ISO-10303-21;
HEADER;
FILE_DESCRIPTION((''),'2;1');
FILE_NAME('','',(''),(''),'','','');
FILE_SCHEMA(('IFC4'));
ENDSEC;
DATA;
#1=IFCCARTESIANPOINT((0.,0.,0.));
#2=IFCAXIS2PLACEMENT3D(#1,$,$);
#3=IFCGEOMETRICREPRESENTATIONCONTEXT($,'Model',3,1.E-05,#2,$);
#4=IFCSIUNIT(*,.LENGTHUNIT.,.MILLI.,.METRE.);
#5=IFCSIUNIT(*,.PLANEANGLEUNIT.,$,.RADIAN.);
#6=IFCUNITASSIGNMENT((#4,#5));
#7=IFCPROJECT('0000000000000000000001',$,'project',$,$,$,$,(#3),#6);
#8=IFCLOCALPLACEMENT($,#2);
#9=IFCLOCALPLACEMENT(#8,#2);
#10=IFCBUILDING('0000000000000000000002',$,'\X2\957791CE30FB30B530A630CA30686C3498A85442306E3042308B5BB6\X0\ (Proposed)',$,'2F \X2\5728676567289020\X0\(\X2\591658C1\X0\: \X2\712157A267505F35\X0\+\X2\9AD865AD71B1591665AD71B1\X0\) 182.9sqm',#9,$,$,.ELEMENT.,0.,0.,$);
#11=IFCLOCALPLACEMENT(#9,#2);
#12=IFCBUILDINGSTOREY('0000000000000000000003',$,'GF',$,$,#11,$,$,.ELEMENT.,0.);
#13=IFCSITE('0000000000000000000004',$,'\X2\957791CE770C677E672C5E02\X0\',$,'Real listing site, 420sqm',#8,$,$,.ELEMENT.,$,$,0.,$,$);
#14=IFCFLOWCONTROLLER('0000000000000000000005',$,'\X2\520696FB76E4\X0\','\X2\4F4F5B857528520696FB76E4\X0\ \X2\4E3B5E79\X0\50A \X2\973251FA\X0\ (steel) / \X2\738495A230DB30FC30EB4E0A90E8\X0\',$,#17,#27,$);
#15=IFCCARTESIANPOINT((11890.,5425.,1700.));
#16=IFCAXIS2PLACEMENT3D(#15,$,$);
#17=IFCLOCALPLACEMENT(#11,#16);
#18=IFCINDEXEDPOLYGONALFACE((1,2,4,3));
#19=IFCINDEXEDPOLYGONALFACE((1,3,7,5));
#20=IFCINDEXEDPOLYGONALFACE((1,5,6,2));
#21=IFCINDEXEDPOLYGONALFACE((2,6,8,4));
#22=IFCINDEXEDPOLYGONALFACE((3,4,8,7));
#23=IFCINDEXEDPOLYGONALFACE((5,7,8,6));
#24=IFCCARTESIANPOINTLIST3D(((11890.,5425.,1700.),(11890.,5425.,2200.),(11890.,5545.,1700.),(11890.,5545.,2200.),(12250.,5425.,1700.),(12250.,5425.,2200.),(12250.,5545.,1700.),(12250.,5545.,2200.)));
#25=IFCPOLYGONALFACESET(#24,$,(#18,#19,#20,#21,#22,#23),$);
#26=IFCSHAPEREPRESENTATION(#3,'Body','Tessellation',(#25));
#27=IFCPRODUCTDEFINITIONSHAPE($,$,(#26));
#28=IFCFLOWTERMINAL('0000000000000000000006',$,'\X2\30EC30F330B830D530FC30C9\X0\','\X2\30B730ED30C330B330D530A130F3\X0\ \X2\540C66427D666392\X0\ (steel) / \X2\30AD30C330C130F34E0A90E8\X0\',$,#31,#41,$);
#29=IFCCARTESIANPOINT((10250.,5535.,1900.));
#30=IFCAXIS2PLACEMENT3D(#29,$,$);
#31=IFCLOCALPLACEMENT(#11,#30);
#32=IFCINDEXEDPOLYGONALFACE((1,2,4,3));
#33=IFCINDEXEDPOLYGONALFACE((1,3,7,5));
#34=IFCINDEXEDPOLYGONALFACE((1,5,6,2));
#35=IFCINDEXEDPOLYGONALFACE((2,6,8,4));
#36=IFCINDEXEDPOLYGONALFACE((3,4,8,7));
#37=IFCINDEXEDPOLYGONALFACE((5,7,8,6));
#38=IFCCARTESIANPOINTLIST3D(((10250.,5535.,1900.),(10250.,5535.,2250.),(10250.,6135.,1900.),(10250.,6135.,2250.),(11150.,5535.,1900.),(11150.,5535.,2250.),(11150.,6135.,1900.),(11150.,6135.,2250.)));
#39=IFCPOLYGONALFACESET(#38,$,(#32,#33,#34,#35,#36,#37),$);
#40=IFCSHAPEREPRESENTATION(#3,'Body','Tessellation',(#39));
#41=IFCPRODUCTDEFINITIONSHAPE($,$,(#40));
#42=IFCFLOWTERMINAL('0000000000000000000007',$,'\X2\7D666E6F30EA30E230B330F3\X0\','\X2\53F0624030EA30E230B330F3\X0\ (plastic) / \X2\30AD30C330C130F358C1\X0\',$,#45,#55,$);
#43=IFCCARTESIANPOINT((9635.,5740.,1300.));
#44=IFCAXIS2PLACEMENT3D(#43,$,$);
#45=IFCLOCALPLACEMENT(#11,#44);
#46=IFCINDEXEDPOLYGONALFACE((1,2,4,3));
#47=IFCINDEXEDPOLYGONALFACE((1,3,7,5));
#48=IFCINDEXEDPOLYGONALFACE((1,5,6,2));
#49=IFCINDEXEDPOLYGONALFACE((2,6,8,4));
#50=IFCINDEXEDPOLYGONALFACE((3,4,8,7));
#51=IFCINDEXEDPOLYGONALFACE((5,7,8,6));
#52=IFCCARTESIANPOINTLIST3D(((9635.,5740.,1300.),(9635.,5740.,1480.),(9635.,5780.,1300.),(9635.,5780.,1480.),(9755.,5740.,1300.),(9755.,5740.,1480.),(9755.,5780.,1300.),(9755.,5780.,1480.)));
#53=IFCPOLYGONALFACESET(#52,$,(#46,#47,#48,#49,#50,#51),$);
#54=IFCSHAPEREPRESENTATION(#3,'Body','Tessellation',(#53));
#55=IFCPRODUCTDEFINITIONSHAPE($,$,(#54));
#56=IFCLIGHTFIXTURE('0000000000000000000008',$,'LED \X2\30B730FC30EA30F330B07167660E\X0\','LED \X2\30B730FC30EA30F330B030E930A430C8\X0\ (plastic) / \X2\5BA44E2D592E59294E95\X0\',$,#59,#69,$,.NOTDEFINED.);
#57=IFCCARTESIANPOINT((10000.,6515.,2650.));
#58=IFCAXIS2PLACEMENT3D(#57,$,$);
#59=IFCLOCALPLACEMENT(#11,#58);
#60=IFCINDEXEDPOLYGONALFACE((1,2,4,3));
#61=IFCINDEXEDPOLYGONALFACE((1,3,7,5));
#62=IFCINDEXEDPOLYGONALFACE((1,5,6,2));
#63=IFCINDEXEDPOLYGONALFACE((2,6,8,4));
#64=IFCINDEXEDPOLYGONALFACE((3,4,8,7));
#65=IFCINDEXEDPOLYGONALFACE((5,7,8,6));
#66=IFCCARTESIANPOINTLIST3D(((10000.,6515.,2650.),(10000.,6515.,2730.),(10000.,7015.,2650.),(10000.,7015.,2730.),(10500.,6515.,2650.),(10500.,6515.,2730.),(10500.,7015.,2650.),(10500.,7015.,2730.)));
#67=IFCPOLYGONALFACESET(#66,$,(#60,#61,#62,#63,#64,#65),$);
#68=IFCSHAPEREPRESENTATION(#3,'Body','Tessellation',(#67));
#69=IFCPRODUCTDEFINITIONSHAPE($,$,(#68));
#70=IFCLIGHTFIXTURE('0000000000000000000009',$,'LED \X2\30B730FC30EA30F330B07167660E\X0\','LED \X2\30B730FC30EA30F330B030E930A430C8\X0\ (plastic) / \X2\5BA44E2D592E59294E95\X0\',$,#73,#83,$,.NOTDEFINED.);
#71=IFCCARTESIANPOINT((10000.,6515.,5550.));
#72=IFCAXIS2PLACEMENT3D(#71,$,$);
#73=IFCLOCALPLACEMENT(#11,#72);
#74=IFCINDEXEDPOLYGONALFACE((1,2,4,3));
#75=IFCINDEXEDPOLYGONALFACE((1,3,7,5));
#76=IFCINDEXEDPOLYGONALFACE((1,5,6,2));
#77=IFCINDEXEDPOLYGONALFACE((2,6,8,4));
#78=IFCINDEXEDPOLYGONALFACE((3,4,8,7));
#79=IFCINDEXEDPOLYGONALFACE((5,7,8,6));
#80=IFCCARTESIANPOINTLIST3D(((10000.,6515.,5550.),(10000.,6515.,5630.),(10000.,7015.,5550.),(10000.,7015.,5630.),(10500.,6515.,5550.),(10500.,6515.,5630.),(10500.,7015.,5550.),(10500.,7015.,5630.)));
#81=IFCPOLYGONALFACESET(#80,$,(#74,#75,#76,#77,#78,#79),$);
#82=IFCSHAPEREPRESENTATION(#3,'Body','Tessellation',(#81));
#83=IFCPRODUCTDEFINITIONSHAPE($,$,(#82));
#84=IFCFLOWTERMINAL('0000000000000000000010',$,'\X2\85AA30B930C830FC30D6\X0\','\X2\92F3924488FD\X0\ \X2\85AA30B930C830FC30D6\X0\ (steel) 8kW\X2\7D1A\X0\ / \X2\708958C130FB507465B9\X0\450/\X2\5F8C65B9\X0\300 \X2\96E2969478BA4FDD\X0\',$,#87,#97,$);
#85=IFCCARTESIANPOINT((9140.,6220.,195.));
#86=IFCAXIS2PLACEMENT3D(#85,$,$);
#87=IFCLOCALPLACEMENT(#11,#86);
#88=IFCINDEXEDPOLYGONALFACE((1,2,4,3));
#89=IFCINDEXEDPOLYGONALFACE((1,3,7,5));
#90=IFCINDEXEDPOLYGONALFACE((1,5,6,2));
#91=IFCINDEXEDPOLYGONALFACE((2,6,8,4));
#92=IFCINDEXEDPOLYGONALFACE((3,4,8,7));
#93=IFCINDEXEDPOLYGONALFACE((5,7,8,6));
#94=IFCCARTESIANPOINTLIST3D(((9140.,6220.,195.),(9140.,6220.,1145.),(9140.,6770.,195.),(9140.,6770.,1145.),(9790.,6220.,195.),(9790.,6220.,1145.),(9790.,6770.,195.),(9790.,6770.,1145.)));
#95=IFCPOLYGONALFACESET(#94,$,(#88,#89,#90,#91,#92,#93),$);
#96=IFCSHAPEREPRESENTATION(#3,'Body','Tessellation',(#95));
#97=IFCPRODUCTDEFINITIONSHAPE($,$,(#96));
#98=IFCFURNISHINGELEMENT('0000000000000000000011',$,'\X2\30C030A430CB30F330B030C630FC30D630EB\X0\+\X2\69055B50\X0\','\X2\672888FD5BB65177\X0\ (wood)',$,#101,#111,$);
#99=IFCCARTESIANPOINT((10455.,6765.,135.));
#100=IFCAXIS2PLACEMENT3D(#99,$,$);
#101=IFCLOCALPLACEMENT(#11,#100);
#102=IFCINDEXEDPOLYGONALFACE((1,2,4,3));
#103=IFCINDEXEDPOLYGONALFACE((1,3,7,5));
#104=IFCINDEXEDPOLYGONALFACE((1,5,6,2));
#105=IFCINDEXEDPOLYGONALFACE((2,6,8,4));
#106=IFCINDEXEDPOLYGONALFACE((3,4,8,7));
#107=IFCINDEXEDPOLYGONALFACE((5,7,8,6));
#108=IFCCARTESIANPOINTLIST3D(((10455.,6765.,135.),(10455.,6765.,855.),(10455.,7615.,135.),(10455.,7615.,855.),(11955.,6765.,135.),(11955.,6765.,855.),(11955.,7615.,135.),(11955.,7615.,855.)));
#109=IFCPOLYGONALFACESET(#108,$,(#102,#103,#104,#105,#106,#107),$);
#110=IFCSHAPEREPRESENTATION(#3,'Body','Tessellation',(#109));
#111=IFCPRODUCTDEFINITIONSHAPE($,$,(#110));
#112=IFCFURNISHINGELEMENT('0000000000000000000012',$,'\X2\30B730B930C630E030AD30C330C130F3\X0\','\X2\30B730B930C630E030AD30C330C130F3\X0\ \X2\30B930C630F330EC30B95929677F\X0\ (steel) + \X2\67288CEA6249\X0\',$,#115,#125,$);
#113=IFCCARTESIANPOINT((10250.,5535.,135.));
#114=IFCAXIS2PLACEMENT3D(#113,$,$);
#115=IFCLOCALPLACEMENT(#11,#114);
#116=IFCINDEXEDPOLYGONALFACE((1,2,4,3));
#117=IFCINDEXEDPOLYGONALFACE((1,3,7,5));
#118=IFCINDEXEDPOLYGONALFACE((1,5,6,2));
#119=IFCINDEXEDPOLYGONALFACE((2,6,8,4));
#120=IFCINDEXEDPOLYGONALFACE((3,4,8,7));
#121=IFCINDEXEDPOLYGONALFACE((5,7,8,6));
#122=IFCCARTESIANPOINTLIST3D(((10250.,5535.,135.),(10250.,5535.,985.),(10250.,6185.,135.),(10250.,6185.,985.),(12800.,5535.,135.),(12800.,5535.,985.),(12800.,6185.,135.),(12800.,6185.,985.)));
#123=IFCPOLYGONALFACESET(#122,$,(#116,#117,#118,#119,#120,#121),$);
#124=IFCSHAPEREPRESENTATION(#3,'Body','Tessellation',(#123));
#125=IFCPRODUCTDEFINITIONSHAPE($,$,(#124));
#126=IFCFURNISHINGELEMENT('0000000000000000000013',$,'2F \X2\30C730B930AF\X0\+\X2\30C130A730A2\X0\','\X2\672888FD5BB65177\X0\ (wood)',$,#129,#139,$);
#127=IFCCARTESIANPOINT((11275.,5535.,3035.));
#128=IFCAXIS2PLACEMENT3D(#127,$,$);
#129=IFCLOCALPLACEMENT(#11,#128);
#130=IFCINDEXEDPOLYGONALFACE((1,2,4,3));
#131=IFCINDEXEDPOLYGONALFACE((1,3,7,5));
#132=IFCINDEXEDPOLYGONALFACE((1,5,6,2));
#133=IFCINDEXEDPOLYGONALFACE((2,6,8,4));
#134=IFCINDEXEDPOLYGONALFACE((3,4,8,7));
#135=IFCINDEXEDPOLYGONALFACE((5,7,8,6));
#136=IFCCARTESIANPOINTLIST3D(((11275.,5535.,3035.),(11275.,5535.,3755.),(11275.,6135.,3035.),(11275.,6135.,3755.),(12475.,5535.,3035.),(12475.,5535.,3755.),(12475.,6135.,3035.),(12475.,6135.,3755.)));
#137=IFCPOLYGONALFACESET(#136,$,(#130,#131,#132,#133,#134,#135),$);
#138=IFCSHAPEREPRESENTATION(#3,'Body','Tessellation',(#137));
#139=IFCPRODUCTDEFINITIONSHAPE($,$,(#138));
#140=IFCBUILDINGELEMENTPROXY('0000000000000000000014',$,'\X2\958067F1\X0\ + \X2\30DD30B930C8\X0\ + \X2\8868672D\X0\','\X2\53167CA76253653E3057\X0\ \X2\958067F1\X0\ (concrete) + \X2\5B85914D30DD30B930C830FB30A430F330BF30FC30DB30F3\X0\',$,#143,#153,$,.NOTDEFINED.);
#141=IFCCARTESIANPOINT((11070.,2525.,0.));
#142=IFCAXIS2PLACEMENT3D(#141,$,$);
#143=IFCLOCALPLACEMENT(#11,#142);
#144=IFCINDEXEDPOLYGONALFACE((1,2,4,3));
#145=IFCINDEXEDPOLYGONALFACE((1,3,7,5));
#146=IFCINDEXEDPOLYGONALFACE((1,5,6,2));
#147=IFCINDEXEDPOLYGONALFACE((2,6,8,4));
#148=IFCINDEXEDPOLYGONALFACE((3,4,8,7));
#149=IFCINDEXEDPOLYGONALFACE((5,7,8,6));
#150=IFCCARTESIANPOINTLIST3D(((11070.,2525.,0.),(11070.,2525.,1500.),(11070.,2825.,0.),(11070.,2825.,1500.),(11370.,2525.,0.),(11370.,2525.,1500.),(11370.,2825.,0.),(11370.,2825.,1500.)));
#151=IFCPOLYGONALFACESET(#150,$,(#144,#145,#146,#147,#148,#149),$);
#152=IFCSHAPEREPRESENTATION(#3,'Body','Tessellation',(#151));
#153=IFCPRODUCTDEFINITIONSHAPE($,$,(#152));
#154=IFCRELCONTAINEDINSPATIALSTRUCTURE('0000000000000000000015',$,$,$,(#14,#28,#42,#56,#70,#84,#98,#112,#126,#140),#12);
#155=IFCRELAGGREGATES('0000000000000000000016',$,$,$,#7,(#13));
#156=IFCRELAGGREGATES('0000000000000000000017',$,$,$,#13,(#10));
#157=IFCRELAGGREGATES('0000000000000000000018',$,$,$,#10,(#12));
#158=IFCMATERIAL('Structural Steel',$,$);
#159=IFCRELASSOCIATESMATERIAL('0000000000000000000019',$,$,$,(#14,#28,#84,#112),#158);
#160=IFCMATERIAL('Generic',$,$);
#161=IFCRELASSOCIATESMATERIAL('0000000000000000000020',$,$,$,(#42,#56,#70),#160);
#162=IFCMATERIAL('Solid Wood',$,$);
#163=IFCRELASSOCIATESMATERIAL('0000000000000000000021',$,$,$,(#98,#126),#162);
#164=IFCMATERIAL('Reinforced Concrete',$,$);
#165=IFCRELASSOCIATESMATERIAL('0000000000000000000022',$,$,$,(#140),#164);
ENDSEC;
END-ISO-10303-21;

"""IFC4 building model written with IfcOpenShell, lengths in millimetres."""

from ifc_helpers import new_model, si_unit, frame, frame_2d, origin, place, context, project, spatial, rectangle, extrude, material, element, save


model = new_model("IFC4")

# Units and contexts
model_context = context("Model", 3, precision=1e-05, world=origin())
ifc_project = project(units=[si_unit("LENGTHUNIT", "METRE", prefix="MILLI"), si_unit("PLANEANGLEUNIT", "RADIAN")], contexts=[model_context])

# Site, building, storey
site_placement = place(None, origin())
site = spatial("IfcSite", under=ifc_project, at=site_placement, Name="長野県松本市", ObjectType="Real listing site, 420sqm", CompositionType="ELEMENT", RefElevation=0.0)
building_placement = place(site_placement, origin())
building = spatial("IfcBuilding", under=site, at=building_placement, Name="長野・サウナと水風呂のある家 (Proposed)", ObjectType="2F 在来木造(外壁: 無垢材張+高断熱外断熱) 182.9sqm", CompositionType="ELEMENT", ElevationOfRefHeight=0.0, ElevationOfTerrain=0.0)
storey_placement = place(building_placement, origin())
storey = spatial("IfcBuildingStorey", under=building, at=storey_placement, Name="GF", CompositionType="ELEMENT", Elevation=0.0)

# Shared definitions
ifc_material_1 = material(Name="Solid Wood")

# Shared definitions
ifc_material_2 = material(Name="Structural Steel")

# Shared definitions
ifc_material_3 = material(Name="Reinforced Concrete")

# Flow controller
flow_controller_placement = place(storey_placement, frame((11890.0, 5425.0, 1700.0)))
element("IfcFlowController", 1, at=flow_controller_placement, inside=storey, material=ifc_material_2, Name="分電盤", Description="住宅用分電盤 主幹50A 露出 (steel) / 玄関ホール上部", context=model_context, shape_type="SweptSolid", body=[
    extrude(rectangle(XDim=360.0, YDim=120.0, at=frame_2d((180.0, 60.0))), frame((11890.0, 5425.0, 1700.0)), (0.0, 0.0, 1.0), 500.0),
])

# Flow terminals
flow_terminal_1_placement = place(storey_placement, frame((10250.0, 5535.0, 1900.0)))
element("IfcFlowTerminal", 2, at=flow_terminal_1_placement, inside=storey, material=ifc_material_2, Name="レンジフード", Description="シロッコファン 同時給排 (steel) / キッチン上部", context=model_context, shape_type="SweptSolid", body=[
    extrude(rectangle(XDim=900.0, YDim=600.0, at=frame_2d((450.0, 300.0))), frame((10250.0, 5535.0, 1900.0)), (0.0, 0.0, 1.0), 350.0),
])
ifc_material_4 = material(Name="Generic")
flow_terminal_2_placement = place(storey_placement, frame((9635.0, 5740.0, 1300.0)))
element("IfcFlowTerminal", 3, at=flow_terminal_2_placement, inside=storey, material=ifc_material_4, Name="給湯リモコン", Description="台所リモコン (plastic) / キッチン壁", context=model_context, shape_type="SweptSolid", body=[
    extrude(rectangle(XDim=120.0, YDim=40.0, at=frame_2d((60.0, 20.0))), frame((9635.0, 5740.0, 1300.0)), (0.0, 0.0, 1.0), 180.0),
])

# Light fixtures
light_fixture_1_placement = place(storey_placement, frame((10000.0, 6515.0, 2650.0)))
element("IfcLightFixture", 4, at=light_fixture_1_placement, inside=storey, material=ifc_material_4, Name="LED シーリング照明", Description="LED シーリングライト (plastic) / 室中央天井", PredefinedType="NOTDEFINED", context=model_context, shape_type="SweptSolid", body=[
    extrude(rectangle(XDim=500.0, YDim=500.0, at=frame_2d((250.0, 250.0))), frame((10000.0, 6515.0, 2650.0)), (0.0, 0.0, 1.0), 80.0),
])
light_fixture_2_placement = place(storey_placement, frame((10000.0, 6515.0, 5550.0)))
element("IfcLightFixture", 5, at=light_fixture_2_placement, inside=storey, material=ifc_material_4, Name="LED シーリング照明", Description="LED シーリングライト (plastic) / 室中央天井", PredefinedType="NOTDEFINED", context=model_context, shape_type="SweptSolid", body=[
    extrude(rectangle(XDim=500.0, YDim=500.0, at=frame_2d((250.0, 250.0))), frame((10000.0, 6515.0, 5550.0)), (0.0, 0.0, 1.0), 80.0),
])

# Flow terminal
flow_terminal_3_placement = place(storey_placement, frame((9140.0, 6220.0, 195.0)))
element("IfcFlowTerminal", 6, at=flow_terminal_3_placement, inside=storey, material=ifc_material_2, Name="薪ストーブ", Description="鋳鉄製 薪ストーブ (steel) 8kW級 / 炉壁・側方450/後方300 離隔確保", context=model_context, shape_type="SweptSolid", body=[
    extrude(rectangle(XDim=650.0, YDim=550.0, at=frame_2d((325.0, 275.0))), frame((9140.0, 6220.0, 195.0)), (0.0, 0.0, 1.0), 950.0),
])

# Furnishing elements
furnishing_1_placement = place(storey_placement, frame((10455.0, 6765.0, 135.0)))
element("IfcFurnishingElement", 7, at=furnishing_1_placement, inside=storey, material=ifc_material_1, Name="ダイニングテーブル+椅子", Description="木製家具 (wood)", context=model_context, shape_type="SweptSolid", body=[
    extrude(rectangle(XDim=1500.0, YDim=850.0, at=frame_2d((750.0, 425.0))), frame((10455.0, 6765.0, 135.0)), (0.0, 0.0, 1.0), 720.0),
])
furnishing_2_placement = place(storey_placement, frame((10250.0, 5535.0, 135.0)))
element("IfcFurnishingElement", 8, at=furnishing_2_placement, inside=storey, material=ifc_material_2, Name="システムキッチン", Description="システムキッチン ステンレス天板 (steel) + 木質扉", context=model_context, shape_type="SweptSolid", body=[
    extrude(rectangle(XDim=2550.0, YDim=650.0, at=frame_2d((1275.0, 325.0))), frame((10250.0, 5535.0, 135.0)), (0.0, 0.0, 1.0), 850.0),
])
furnishing_3_placement = place(storey_placement, frame((11275.0, 5535.0, 3035.0)))
element("IfcFurnishingElement", 9, at=furnishing_3_placement, inside=storey, material=ifc_material_1, Name="2F デスク+チェア", Description="木製家具 (wood)", context=model_context, shape_type="SweptSolid", body=[
    extrude(rectangle(XDim=1200.0, YDim=600.0, at=frame_2d((600.0, 300.0))), frame((11275.0, 5535.0, 3035.0)), (0.0, 0.0, 1.0), 720.0),
])

# Building element proxy
proxy_placement = place(storey_placement, frame((11070.0, 2525.0, 0.0)))
element("IfcBuildingElementProxy", 10, at=proxy_placement, inside=storey, material=ifc_material_3, Name="門柱 + ポスト + 表札", Description="化粧打放し 門柱 (concrete) + 宅配ポスト・インターホン", PredefinedType="NOTDEFINED", context=model_context, shape_type="SweptSolid", body=[
    extrude(rectangle(XDim=300.0, YDim=300.0, at=frame_2d((150.0, 150.0))), frame((11070.0, 2525.0, 0.0)), (0.0, 0.0, 1.0), 1500.0),
])

save(model, "model.ifc")
